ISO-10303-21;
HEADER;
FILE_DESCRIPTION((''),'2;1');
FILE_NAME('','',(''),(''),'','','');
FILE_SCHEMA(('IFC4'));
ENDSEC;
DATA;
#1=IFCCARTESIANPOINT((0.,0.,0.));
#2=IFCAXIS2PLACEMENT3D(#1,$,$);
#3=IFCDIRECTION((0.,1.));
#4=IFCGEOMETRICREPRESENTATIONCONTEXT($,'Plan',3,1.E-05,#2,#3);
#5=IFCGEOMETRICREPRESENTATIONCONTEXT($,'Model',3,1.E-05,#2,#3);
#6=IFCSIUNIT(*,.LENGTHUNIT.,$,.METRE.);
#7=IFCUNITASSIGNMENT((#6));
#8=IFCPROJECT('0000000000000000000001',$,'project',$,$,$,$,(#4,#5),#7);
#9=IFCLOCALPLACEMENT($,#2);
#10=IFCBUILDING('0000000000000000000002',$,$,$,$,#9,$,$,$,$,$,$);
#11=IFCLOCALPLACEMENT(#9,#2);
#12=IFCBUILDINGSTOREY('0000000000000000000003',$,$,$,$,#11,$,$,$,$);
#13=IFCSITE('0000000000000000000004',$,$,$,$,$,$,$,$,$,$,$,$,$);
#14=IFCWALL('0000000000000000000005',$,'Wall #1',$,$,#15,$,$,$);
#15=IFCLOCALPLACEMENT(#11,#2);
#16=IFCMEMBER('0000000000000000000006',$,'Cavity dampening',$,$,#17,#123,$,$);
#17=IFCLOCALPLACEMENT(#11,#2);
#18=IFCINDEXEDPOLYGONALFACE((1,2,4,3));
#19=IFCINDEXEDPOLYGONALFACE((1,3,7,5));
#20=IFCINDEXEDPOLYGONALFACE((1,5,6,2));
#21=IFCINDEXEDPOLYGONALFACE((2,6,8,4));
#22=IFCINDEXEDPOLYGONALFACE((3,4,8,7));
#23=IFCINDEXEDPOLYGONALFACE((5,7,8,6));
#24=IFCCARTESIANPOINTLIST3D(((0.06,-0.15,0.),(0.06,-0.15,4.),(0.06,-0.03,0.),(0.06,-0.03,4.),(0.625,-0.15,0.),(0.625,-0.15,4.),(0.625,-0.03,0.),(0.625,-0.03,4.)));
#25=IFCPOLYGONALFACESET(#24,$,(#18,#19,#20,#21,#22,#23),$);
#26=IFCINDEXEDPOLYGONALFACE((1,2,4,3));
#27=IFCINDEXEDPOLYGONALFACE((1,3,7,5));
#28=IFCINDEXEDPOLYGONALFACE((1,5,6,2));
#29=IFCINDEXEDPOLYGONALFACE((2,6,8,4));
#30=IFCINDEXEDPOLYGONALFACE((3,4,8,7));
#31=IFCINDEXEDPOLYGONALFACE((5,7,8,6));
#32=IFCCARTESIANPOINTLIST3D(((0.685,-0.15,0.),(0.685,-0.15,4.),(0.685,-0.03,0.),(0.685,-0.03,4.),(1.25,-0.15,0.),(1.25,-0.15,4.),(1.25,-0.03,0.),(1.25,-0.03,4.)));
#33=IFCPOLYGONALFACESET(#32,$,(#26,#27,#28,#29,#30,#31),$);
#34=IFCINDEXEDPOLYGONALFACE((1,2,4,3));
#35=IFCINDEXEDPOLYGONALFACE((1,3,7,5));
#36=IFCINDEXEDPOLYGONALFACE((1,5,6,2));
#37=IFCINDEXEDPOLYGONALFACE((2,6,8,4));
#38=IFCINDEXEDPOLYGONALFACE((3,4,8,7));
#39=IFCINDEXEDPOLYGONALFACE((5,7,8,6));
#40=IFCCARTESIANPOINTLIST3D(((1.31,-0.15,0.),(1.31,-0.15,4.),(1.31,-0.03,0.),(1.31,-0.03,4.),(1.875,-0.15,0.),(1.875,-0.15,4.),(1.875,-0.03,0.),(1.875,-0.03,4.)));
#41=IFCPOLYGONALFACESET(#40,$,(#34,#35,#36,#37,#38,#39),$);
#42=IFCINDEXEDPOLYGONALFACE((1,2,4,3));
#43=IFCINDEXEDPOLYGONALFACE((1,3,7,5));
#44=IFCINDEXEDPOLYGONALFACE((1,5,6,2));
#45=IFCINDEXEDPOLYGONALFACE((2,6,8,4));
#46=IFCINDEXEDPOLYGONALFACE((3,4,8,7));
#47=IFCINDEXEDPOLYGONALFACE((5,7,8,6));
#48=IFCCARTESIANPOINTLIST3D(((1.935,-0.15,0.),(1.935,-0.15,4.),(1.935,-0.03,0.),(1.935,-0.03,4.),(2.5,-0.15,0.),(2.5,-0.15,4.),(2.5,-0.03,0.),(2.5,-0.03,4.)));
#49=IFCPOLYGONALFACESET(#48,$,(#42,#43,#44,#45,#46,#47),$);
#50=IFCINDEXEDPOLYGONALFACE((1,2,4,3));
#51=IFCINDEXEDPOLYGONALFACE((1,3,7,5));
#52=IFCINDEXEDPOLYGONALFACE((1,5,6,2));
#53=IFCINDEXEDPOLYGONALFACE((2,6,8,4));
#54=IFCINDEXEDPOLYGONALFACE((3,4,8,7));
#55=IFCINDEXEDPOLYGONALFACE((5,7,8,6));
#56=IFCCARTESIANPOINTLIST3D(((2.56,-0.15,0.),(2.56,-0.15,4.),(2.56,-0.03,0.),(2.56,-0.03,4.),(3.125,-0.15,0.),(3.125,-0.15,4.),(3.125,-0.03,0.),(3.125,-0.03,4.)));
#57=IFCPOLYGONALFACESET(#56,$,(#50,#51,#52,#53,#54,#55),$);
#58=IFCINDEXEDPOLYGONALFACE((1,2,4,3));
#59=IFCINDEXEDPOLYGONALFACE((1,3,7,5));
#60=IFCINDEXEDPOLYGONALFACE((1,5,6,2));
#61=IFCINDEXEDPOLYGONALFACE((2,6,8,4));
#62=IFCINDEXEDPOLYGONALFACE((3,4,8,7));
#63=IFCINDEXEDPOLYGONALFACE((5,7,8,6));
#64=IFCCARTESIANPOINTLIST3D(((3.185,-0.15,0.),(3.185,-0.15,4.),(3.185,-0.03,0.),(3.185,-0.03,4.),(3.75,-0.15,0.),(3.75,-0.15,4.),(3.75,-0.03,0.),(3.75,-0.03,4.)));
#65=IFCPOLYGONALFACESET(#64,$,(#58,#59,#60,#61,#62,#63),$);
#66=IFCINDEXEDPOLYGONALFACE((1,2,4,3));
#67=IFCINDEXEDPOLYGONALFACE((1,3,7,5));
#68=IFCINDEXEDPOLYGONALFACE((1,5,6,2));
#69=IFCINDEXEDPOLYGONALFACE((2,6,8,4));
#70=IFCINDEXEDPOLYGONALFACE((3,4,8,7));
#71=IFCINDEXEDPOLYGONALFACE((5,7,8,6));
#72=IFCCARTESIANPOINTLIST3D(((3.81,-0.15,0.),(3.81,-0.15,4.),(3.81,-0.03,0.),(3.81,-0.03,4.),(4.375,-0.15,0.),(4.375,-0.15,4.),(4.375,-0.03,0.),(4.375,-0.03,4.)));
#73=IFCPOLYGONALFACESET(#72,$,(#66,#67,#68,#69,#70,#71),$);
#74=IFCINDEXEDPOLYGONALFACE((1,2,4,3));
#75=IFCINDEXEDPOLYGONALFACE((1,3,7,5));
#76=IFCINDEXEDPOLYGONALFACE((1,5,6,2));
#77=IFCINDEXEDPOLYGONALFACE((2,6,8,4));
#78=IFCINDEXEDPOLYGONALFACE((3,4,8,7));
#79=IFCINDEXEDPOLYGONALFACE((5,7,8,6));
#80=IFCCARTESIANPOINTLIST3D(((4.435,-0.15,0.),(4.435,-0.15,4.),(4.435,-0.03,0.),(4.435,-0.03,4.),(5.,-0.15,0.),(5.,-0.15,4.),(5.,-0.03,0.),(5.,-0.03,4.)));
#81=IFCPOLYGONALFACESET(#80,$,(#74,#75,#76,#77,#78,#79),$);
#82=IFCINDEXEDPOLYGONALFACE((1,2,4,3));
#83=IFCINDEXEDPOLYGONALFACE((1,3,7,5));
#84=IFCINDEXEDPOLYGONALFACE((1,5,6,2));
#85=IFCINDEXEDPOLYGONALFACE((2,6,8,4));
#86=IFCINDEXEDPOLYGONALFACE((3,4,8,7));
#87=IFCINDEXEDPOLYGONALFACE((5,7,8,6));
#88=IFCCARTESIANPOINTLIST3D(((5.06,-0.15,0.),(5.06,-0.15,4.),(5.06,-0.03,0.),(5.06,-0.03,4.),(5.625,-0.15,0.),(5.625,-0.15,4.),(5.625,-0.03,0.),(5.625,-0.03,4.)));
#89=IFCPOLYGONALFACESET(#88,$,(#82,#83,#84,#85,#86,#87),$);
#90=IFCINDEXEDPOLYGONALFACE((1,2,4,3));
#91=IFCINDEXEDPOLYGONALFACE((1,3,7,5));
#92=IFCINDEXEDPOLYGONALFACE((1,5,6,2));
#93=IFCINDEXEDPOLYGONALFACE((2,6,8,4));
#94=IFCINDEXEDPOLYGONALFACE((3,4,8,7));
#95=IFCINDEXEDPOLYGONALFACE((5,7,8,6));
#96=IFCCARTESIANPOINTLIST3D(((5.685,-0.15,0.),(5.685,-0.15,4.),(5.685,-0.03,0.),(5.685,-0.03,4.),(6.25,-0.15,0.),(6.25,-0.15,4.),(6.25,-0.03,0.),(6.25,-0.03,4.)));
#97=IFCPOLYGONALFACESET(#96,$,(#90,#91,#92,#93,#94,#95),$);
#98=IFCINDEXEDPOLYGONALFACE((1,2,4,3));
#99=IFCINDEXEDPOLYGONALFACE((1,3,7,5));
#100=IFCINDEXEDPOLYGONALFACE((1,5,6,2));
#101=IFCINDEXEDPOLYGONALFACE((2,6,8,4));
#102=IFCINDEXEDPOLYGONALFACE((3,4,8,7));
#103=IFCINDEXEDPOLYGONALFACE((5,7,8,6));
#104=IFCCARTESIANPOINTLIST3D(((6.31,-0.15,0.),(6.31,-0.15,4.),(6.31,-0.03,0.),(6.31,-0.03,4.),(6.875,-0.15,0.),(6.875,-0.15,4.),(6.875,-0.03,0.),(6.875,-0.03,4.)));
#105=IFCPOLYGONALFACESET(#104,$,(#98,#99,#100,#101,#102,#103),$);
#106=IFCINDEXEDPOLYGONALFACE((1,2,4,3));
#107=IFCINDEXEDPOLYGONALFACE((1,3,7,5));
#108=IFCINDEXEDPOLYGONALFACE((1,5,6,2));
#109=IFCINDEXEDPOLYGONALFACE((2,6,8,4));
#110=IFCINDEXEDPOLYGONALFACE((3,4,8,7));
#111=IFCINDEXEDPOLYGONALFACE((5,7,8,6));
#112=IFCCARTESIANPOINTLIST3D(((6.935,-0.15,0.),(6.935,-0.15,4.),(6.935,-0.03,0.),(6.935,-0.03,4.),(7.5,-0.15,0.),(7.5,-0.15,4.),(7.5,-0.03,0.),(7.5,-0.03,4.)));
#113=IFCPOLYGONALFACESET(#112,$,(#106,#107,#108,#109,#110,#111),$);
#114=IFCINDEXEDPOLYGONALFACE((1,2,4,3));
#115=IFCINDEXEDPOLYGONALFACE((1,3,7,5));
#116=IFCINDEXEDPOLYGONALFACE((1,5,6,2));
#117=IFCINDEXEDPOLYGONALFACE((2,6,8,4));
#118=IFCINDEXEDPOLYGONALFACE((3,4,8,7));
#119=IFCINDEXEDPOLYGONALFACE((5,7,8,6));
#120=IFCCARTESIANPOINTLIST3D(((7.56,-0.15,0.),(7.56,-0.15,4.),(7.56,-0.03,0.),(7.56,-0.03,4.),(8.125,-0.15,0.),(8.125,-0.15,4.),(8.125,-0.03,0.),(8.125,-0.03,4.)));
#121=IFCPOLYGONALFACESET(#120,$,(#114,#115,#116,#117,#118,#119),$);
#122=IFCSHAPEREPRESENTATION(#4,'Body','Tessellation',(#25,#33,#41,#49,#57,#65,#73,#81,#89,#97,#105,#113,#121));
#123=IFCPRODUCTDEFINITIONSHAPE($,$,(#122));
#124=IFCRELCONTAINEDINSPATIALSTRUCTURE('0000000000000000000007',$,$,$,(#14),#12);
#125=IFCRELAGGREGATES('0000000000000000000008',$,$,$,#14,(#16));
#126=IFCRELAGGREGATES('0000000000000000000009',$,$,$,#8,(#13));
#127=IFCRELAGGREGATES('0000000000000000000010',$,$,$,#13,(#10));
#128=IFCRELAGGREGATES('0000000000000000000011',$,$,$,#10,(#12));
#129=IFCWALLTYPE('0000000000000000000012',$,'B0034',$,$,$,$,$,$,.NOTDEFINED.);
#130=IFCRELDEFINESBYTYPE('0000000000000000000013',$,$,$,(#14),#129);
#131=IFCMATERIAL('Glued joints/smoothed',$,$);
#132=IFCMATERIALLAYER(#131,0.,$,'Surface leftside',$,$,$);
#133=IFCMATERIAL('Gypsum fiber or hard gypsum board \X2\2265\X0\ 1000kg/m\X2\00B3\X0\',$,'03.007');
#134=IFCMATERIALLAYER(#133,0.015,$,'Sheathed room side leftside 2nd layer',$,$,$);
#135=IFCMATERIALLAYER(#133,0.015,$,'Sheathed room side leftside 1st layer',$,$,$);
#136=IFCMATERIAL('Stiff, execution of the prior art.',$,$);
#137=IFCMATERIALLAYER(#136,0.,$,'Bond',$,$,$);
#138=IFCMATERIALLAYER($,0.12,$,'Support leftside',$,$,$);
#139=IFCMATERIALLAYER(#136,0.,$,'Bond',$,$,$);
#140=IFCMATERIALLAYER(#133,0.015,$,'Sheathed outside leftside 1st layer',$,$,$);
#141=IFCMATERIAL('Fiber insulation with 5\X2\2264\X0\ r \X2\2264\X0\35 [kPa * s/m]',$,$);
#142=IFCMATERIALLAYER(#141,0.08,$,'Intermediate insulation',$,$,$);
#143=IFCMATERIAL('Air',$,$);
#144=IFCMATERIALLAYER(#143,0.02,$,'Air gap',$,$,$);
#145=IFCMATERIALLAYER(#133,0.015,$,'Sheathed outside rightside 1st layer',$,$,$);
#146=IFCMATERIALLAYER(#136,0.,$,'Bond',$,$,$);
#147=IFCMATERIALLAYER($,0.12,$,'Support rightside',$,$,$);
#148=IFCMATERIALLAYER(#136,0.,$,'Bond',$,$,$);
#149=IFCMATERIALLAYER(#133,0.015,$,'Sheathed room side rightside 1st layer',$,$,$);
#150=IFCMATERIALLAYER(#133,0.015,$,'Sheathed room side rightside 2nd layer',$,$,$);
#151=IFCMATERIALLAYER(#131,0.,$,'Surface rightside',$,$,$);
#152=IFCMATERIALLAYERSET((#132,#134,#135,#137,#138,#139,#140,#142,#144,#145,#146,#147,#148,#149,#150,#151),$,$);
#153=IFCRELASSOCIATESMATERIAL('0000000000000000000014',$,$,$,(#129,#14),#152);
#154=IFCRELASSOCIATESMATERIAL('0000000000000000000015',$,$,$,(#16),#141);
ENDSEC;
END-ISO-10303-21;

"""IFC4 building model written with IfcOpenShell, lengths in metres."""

from ifc_helpers import new_model, si_unit, direction, frame, frame_2d, origin, place, context, project, spatial, rectangle, extrude, material, layer, layer_set, type_object, element, aggregate, save


model = new_model("IFC4")

# Units and contexts
plan_context = context("Plan", 3, precision=1e-05, world=origin(), true_north=direction((0.0, 1.0)))
model_context = context("Model", 3, precision=1e-05, world=origin(), true_north=direction((0.0, 1.0)))
ifc_project = project(units=[si_unit("LENGTHUNIT", "METRE")], contexts=[plan_context, model_context])

# Site, building, storey
site = spatial("IfcSite", under=ifc_project)
building_placement = place(None, origin())
building = spatial("IfcBuilding", under=site, at=building_placement)
storey_placement = place(building_placement, origin())
storey = spatial("IfcBuildingStorey", under=building, at=storey_placement)

# Wall, member
ifc_material_1 = material(Name="Glued joints/smoothed")
ifc_layer_1 = layer(ifc_material_1, 0.0, Name="Surface leftside")
ifc_material_2 = material(Name="Gypsum fiber or hard gypsum board ≥ 1000kg/m³", Category="03.007")
ifc_layer_2 = layer(ifc_material_2, 0.015, Name="Sheathed room side leftside 2nd layer")
ifc_layer_3 = layer(ifc_material_2, 0.015, Name="Sheathed room side leftside 1st layer")
ifc_material_3 = material(Name="Stiff, execution of the prior art.")
ifc_layer_4 = layer(ifc_material_3, 0.0, Name="Bond")
ifc_layer_5 = layer(None, 0.12, Name="Support leftside")
ifc_layer_6 = layer(ifc_material_3, 0.0, Name="Bond")
ifc_layer_7 = layer(ifc_material_2, 0.015, Name="Sheathed outside leftside 1st layer")
ifc_material_4 = material(Name="Fiber insulation with 5≤ r ≤35 [kPa * s/m]")
ifc_layer_8 = layer(ifc_material_4, 0.08, Name="Intermediate insulation")
ifc_material_5 = material(Name="Air")
ifc_layer_9 = layer(ifc_material_5, 0.02, Name="Air gap")
ifc_layer_10 = layer(ifc_material_2, 0.015, Name="Sheathed outside rightside 1st layer")
ifc_layer_11 = layer(ifc_material_3, 0.0, Name="Bond")
ifc_layer_12 = layer(None, 0.12, Name="Support rightside")
ifc_layer_13 = layer(ifc_material_3, 0.0, Name="Bond")
ifc_layer_14 = layer(ifc_material_2, 0.015, Name="Sheathed room side rightside 1st layer")
ifc_layer_15 = layer(ifc_material_2, 0.015, Name="Sheathed room side rightside 2nd layer")
ifc_layer_16 = layer(ifc_material_1, 0.0, Name="Surface rightside")
ifc_layer_set = layer_set([ifc_layer_1, ifc_layer_2, ifc_layer_3, ifc_layer_4, ifc_layer_5, ifc_layer_6, ifc_layer_7, ifc_layer_8, ifc_layer_9, ifc_layer_10, ifc_layer_11, ifc_layer_12, ifc_layer_13, ifc_layer_14, ifc_layer_15, ifc_layer_16])
wall_type = type_object("IfcWallType", Name="B0034", PredefinedType="NOTDEFINED", material=ifc_layer_set)
wall_placement = place(None, frame((0.0, 0.0, 0.0), z_axis=(0.0, -1.0, 0.0), x_axis=(1.0, 0.0, 0.0)))
wall = element("IfcWall", 1, at=wall_placement, inside=storey, type_object=wall_type, material=ifc_layer_set, Name="Wall #1")
member_1_placement = place(wall_placement, origin())
member_1 = element("IfcMember", 2, at=member_1_placement, material=ifc_material_4, Name="Cavity dampening", context=plan_context, shape_type="SweptSolid", body=[
    extrude(rectangle(XDim=0.565, YDim=0.12, at=frame_2d((0.2825, 0.06), x_axis=(1.0, 0.0))), frame((0.06, 4.0, 0.03), z_axis=(0.0, -1.0, 0.0), x_axis=(1.0, 0.0, 0.0)), (0.0, 0.0, 1.0), 4.0),
    extrude(rectangle(XDim=0.565, YDim=0.12, at=frame_2d((0.2825, 0.06), x_axis=(1.0, 0.0))), frame((0.685, 4.0, 0.03), z_axis=(0.0, -1.0, 0.0), x_axis=(1.0, 0.0, 0.0)), (0.0, 0.0, 1.0), 4.0),
    extrude(rectangle(XDim=0.565, YDim=0.12, at=frame_2d((0.2825, 0.06), x_axis=(1.0, 0.0))), frame((1.31, 4.0, 0.03), z_axis=(0.0, -1.0, 0.0), x_axis=(1.0, 0.0, 0.0)), (0.0, 0.0, 1.0), 4.0),
    extrude(rectangle(XDim=0.565, YDim=0.12, at=frame_2d((0.2825, 0.06), x_axis=(1.0, 0.0))), frame((1.935, 4.0, 0.03), z_axis=(0.0, -1.0, 0.0), x_axis=(1.0, 0.0, 0.0)), (0.0, 0.0, 1.0), 4.0),
    extrude(rectangle(XDim=0.565, YDim=0.12, at=frame_2d((0.2825, 0.06), x_axis=(1.0, 0.0))), frame((2.56, 4.0, 0.03), z_axis=(0.0, -1.0, 0.0), x_axis=(1.0, 0.0, 0.0)), (0.0, 0.0, 1.0), 4.0),
    extrude(rectangle(XDim=0.565, YDim=0.12, at=frame_2d((0.2825, 0.06), x_axis=(1.0, 0.0))), frame((3.185, 4.0, 0.03), z_axis=(0.0, -1.0, 0.0), x_axis=(1.0, 0.0, 0.0)), (0.0, 0.0, 1.0), 4.0),
    extrude(rectangle(XDim=0.565, YDim=0.12, at=frame_2d((0.2825, 0.06), x_axis=(1.0, 0.0))), frame((3.81, 4.0, 0.03), z_axis=(0.0, -1.0, 0.0), x_axis=(1.0, 0.0, 0.0)), (0.0, 0.0, 1.0), 4.0),
    extrude(rectangle(XDim=0.565, YDim=0.12, at=frame_2d((0.2825, 0.06), x_axis=(1.0, 0.0))), frame((4.435, 4.0, 0.03), z_axis=(0.0, -1.0, 0.0), x_axis=(1.0, 0.0, 0.0)), (0.0, 0.0, 1.0), 4.0),
    extrude(rectangle(XDim=0.565, YDim=0.12, at=frame_2d((0.2825, 0.06), x_axis=(1.0, 0.0))), frame((5.06, 4.0, 0.03), z_axis=(0.0, -1.0, 0.0), x_axis=(1.0, 0.0, 0.0)), (0.0, 0.0, 1.0), 4.0),
    extrude(rectangle(XDim=0.565, YDim=0.12, at=frame_2d((0.2825, 0.06), x_axis=(1.0, 0.0))), frame((5.685, 4.0, 0.03), z_axis=(0.0, -1.0, 0.0), x_axis=(1.0, 0.0, 0.0)), (0.0, 0.0, 1.0), 4.0),
    extrude(rectangle(XDim=0.565, YDim=0.12, at=frame_2d((0.2825, 0.06), x_axis=(1.0, 0.0))), frame((6.31, 4.0, 0.03), z_axis=(0.0, -1.0, 0.0), x_axis=(1.0, 0.0, 0.0)), (0.0, 0.0, 1.0), 4.0),
    extrude(rectangle(XDim=0.565, YDim=0.12, at=frame_2d((0.2825, 0.06), x_axis=(1.0, 0.0))), frame((6.935, 4.0, 0.03), z_axis=(0.0, -1.0, 0.0), x_axis=(1.0, 0.0, 0.0)), (0.0, 0.0, 1.0), 4.0),
    extrude(rectangle(XDim=0.565, YDim=0.12, at=frame_2d((0.2825, 0.06), x_axis=(1.0, 0.0))), frame((7.56, 4.0, 0.03), z_axis=(0.0, -1.0, 0.0), x_axis=(1.0, 0.0, 0.0)), (0.0, 0.0, 1.0), 4.0),
])
aggregate(wall, [member_1])

save(model, "model.ifc")
